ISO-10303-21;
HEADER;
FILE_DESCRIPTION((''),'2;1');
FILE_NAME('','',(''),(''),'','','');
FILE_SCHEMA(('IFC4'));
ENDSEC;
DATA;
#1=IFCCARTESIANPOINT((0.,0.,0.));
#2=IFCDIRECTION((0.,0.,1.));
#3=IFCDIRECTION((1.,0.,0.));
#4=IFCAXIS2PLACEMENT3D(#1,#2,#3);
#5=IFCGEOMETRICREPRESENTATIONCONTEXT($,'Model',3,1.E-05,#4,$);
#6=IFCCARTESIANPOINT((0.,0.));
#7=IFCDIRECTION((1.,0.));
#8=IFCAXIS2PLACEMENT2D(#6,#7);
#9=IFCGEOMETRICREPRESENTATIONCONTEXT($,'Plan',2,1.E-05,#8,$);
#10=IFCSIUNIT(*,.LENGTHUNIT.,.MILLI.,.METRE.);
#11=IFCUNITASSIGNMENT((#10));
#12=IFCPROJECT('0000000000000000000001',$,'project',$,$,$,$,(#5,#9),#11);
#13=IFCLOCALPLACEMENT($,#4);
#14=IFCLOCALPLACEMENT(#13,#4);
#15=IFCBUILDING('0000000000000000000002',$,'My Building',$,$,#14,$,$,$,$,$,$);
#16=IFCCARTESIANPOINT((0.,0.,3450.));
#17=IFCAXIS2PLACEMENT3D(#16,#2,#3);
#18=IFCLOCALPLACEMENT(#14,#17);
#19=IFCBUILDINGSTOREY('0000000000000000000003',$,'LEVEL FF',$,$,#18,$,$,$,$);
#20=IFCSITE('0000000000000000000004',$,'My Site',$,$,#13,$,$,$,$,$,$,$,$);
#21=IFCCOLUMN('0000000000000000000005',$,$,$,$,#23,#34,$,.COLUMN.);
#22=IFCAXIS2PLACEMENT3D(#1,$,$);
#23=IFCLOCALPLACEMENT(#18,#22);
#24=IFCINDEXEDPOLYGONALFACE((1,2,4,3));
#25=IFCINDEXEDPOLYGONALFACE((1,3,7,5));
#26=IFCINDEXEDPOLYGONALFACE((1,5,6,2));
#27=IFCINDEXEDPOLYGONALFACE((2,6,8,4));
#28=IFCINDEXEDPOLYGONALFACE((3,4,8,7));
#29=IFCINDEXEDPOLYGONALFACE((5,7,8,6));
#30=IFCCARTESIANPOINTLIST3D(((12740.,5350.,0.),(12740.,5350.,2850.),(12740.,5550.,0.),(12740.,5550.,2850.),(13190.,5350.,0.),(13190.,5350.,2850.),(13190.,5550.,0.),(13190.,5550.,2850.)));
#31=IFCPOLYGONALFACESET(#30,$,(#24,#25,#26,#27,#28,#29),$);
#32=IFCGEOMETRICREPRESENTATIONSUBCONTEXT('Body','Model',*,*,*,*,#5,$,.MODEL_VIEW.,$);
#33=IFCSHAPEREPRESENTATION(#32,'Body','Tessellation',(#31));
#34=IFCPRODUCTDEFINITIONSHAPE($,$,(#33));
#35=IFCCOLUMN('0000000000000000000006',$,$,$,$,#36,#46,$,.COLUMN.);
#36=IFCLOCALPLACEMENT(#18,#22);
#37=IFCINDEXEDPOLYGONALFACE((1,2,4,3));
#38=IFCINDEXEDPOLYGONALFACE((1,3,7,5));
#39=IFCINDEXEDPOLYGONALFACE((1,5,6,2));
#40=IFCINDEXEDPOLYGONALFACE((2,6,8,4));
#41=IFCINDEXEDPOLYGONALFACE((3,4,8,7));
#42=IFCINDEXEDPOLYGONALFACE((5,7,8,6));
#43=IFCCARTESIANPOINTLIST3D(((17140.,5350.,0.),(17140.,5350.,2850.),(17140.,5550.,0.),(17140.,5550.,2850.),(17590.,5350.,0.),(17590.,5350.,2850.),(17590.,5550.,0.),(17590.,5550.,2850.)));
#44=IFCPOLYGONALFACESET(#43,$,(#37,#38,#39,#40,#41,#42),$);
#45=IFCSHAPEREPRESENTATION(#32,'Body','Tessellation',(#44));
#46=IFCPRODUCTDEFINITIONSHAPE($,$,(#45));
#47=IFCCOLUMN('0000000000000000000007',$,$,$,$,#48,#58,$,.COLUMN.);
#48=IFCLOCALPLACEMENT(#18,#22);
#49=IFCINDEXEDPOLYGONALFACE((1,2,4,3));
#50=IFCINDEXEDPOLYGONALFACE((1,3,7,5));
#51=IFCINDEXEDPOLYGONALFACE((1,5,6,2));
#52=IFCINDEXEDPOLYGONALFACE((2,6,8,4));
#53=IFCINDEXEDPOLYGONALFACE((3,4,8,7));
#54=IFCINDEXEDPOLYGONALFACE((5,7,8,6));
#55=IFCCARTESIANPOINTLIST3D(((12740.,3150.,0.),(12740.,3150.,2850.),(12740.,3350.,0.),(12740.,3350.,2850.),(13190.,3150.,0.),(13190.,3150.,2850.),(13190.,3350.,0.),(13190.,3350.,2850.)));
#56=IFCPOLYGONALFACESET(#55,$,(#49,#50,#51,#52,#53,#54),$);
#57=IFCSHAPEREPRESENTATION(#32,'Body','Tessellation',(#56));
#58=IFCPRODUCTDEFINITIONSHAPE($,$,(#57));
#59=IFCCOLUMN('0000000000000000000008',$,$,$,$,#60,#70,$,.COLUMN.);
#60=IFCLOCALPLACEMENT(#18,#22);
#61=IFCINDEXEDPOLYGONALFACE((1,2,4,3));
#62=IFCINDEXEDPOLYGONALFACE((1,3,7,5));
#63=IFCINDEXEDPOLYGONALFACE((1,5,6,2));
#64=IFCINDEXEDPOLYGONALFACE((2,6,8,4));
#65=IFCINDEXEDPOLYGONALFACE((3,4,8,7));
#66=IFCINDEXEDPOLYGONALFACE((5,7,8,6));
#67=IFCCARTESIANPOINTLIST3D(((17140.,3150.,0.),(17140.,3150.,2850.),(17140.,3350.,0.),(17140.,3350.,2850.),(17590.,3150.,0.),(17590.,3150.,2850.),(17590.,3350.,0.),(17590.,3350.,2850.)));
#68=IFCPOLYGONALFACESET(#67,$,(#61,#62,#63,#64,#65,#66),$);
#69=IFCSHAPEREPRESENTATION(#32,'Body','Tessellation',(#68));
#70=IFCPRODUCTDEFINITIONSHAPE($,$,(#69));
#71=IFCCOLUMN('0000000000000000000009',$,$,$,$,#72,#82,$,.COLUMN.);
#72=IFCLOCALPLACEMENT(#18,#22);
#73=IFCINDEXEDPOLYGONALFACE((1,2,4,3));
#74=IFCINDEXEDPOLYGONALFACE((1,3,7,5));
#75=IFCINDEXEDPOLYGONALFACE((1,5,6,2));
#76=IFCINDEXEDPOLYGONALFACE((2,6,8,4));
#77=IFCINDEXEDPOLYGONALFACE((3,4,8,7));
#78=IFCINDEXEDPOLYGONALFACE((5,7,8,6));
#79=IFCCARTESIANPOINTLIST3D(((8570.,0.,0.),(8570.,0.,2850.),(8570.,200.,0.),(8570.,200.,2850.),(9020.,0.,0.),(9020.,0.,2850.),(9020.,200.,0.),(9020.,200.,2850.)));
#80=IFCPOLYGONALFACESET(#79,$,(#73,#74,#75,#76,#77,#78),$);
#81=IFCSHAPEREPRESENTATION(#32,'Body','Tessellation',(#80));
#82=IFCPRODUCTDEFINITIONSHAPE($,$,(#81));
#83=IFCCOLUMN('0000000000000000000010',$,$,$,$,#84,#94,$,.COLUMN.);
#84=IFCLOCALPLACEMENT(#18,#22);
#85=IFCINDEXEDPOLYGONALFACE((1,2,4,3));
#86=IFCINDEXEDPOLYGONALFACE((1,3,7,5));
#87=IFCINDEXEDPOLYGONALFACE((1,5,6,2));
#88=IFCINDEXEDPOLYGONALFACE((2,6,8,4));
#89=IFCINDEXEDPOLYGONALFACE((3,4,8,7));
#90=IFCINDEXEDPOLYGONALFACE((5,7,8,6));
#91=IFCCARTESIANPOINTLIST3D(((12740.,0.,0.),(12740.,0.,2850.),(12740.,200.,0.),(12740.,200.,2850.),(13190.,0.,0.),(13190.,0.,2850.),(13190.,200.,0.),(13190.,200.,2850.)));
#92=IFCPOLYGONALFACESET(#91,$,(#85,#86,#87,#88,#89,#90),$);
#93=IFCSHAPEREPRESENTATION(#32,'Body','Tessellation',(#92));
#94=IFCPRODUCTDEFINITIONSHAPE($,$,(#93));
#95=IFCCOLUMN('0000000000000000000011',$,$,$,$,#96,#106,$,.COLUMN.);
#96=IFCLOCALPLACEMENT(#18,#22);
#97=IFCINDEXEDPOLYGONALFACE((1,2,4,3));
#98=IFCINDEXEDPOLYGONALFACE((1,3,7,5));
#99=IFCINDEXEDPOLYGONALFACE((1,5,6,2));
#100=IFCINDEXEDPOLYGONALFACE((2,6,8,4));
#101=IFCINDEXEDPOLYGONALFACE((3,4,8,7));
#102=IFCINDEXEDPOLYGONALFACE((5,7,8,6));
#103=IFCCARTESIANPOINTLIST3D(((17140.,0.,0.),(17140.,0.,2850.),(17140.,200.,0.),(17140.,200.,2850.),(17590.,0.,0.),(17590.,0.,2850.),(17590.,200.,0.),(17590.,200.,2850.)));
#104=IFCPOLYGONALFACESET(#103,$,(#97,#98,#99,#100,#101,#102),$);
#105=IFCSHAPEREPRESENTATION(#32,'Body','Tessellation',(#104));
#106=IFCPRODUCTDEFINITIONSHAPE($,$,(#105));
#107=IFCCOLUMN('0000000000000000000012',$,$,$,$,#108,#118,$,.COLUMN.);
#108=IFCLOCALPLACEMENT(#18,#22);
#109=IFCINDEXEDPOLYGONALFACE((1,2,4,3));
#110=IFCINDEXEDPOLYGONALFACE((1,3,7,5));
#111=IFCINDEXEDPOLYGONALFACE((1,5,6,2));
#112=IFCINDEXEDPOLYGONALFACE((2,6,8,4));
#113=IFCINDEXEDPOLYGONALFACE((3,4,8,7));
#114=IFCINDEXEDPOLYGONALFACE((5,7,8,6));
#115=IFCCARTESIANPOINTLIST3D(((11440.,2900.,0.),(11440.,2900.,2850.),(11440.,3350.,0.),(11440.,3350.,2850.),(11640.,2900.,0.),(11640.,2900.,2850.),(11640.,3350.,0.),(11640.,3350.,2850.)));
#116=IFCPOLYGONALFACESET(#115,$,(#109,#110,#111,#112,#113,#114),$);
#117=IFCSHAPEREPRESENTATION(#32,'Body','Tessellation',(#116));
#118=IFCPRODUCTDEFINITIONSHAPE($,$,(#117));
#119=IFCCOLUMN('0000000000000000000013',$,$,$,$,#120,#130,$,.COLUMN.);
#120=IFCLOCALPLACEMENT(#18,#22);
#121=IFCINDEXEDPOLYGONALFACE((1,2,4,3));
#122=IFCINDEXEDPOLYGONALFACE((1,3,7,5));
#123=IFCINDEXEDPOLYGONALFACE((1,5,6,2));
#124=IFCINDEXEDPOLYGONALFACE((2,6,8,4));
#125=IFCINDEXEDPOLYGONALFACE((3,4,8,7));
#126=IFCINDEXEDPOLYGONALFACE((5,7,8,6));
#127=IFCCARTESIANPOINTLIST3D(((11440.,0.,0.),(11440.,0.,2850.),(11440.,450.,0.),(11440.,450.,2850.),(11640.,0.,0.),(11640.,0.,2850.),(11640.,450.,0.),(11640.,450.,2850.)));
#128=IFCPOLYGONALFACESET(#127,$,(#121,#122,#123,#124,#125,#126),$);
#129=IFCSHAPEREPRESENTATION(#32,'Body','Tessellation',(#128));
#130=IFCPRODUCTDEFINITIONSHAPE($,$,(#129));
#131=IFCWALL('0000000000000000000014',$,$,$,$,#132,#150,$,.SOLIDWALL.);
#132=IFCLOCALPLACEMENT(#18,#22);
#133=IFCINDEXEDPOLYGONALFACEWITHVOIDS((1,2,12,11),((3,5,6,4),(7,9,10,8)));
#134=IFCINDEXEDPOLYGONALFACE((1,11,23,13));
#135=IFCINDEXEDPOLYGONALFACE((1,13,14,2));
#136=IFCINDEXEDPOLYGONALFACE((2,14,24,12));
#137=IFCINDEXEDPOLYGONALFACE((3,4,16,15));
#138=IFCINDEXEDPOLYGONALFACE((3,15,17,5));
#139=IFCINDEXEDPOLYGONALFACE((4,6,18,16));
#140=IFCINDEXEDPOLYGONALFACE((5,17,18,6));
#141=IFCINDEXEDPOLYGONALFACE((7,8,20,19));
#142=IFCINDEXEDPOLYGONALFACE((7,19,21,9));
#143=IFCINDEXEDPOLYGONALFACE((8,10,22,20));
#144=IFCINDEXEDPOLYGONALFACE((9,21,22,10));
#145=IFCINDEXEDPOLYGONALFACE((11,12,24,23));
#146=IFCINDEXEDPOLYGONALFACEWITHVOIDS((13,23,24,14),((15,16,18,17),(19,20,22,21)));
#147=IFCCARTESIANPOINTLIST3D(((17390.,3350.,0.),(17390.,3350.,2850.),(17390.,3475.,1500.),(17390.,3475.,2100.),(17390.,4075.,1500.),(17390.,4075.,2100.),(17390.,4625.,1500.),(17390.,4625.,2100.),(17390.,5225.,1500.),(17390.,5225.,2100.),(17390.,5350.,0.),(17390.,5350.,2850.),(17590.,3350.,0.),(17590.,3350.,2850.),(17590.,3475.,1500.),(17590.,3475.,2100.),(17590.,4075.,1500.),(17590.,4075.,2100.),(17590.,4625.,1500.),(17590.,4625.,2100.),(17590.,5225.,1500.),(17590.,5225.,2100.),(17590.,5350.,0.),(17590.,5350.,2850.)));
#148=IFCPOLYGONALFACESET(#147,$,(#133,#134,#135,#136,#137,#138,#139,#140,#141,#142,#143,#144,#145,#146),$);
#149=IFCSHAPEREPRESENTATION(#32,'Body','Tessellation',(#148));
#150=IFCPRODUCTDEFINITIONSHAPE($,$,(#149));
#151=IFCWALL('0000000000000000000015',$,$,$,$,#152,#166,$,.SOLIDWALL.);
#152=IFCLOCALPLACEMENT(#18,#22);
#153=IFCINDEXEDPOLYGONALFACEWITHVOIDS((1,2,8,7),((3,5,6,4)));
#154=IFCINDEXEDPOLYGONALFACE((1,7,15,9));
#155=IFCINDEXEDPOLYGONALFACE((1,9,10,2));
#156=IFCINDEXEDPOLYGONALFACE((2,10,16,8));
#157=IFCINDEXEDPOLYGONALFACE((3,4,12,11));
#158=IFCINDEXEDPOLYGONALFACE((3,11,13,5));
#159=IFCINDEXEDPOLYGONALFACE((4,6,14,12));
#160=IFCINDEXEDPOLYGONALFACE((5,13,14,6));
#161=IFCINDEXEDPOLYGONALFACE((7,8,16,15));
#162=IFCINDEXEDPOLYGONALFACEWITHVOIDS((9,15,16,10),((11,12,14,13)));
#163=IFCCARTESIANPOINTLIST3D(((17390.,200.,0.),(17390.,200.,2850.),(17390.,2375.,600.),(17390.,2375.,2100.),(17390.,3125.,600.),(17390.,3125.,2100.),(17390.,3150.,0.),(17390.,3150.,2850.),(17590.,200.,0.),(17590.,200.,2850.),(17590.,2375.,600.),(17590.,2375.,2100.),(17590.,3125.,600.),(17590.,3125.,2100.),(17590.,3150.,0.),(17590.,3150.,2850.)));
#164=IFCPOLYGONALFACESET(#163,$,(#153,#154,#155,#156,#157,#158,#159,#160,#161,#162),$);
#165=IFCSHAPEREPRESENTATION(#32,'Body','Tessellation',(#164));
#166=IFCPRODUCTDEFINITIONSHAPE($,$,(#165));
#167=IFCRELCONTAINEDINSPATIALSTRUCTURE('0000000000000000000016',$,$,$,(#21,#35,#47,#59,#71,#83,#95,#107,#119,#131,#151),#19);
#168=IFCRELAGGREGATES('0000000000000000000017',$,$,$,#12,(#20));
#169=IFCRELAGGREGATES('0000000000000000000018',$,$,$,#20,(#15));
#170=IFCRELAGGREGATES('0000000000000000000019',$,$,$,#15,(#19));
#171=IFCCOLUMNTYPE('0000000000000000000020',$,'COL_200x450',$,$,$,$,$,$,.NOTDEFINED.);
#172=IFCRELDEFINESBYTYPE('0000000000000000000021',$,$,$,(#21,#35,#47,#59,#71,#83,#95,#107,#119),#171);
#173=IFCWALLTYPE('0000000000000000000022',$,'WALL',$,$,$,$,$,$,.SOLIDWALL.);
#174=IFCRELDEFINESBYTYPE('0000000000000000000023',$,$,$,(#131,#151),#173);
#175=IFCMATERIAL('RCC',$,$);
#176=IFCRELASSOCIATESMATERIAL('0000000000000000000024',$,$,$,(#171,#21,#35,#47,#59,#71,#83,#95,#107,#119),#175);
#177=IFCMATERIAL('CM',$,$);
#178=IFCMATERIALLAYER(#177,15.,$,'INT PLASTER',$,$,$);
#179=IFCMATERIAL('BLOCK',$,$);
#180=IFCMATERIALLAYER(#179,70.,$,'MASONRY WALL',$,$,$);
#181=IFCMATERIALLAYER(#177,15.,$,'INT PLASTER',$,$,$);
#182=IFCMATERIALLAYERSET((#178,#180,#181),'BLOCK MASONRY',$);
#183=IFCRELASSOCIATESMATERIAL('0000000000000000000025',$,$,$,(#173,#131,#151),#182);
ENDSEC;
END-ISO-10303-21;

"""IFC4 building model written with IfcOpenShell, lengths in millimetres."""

from ifc_helpers import new_model, si_unit, frame, origin_with_axes, origin_2d_with_axis, place, context, subcontext, project, spatial, indexed_curve, rectangle, outline, extrude, material, layer, layer_set, layer_usage, material_profile, profile_set, profile_usage, type_object, element, save


model = new_model("IFC4")

# Units and contexts
model_context = context("Model", 3, precision=1e-05, world=origin_with_axes())
plan_context = context("Plan", 2, precision=1e-05, world=origin_2d_with_axis())
body_context = subcontext(model_context, "Body", "Model", "MODEL_VIEW")
ifc_project = project(units=[si_unit("LENGTHUNIT", "METRE", prefix="MILLI")], contexts=[model_context, plan_context])

# Site, building, storey
site_placement = place(None, origin_with_axes())
site = spatial("IfcSite", under=ifc_project, at=site_placement, Name="My Site")
building_placement = place(site_placement, origin_with_axes())
building = spatial("IfcBuilding", under=site, at=building_placement, Name="My Building")
storey_placement = place(building_placement, frame((0.0, 0.0, 3450.0), z_axis=(0.0, 0.0, 1.0), x_axis=(1.0, 0.0, 0.0)))
storey = spatial("IfcBuildingStorey", under=building, at=storey_placement, Name="LEVEL FF")

# Columns
ifc_material_1 = material(Name="RCC")
ifc_material_profile = material_profile(ifc_material_1, rectangle(XDim=200.0, YDim=450.0))
ifc_profile_set = profile_set([ifc_material_profile], Name="COL_200x450")
ifc_profile_usage_1 = profile_usage(ifc_profile_set)
column_type = type_object("IfcColumnType", Name="COL_200x450", PredefinedType="NOTDEFINED", material=ifc_profile_set)
column_1_placement = place(storey_placement, frame((12965.0, 5450.0, 0.0), z_axis=(0.0, 0.0, 1.0), x_axis=(0.0, -1.0, 0.0)))
element("IfcColumn", 1, at=column_1_placement, inside=storey, type_object=column_type, material=ifc_profile_usage_1, PredefinedType="COLUMN", context=body_context, shape_type="SweptSolid", body=[
    extrude(rectangle(XDim=200.0, YDim=450.0), origin_with_axes(), (0.0, 0.0, 1.0), 2850.0),
])
ifc_profile_usage_2 = profile_usage(ifc_profile_set)
column_2_placement = place(storey_placement, frame((17365.0, 5450.0, 0.0), z_axis=(0.0, 0.0, 1.0), x_axis=(0.0, -1.0, 0.0)))
element("IfcColumn", 2, at=column_2_placement, inside=storey, type_object=column_type, material=ifc_profile_usage_2, PredefinedType="COLUMN", context=body_context, shape_type="SweptSolid", body=[
    extrude(rectangle(XDim=200.0, YDim=450.0), origin_with_axes(), (0.0, 0.0, 1.0), 2850.0),
])
ifc_profile_usage_3 = profile_usage(ifc_profile_set)
column_3_placement = place(storey_placement, frame((12965.0, 3250.0, 0.0), z_axis=(0.0, 0.0, 1.0), x_axis=(0.0, -1.0, 0.0)))
element("IfcColumn", 3, at=column_3_placement, inside=storey, type_object=column_type, material=ifc_profile_usage_3, PredefinedType="COLUMN", context=body_context, shape_type="SweptSolid", body=[
    extrude(rectangle(XDim=200.0, YDim=450.0), origin_with_axes(), (0.0, 0.0, 1.0), 2850.0),
])
ifc_profile_usage_4 = profile_usage(ifc_profile_set)
column_4_placement = place(storey_placement, frame((17365.0, 3250.0, 0.0), z_axis=(0.0, 0.0, 1.0), x_axis=(0.0, -1.0, 0.0)))
element("IfcColumn", 4, at=column_4_placement, inside=storey, type_object=column_type, material=ifc_profile_usage_4, PredefinedType="COLUMN", context=body_context, shape_type="SweptSolid", body=[
    extrude(rectangle(XDim=200.0, YDim=450.0), origin_with_axes(), (0.0, 0.0, 1.0), 2850.0),
])
ifc_profile_usage_5 = profile_usage(ifc_profile_set)
column_5_placement = place(storey_placement, frame((8795.0, 100.0, 0.0), z_axis=(0.0, 0.0, 1.0), x_axis=(0.0, -1.0, 0.0)))
element("IfcColumn", 5, at=column_5_placement, inside=storey, type_object=column_type, material=ifc_profile_usage_5, PredefinedType="COLUMN", context=body_context, shape_type="SweptSolid", body=[
    extrude(rectangle(XDim=200.0, YDim=450.0), origin_with_axes(), (0.0, 0.0, 1.0), 2850.0),
])
ifc_profile_usage_6 = profile_usage(ifc_profile_set)
column_6_placement = place(storey_placement, frame((12965.0, 100.0, 0.0), z_axis=(0.0, 0.0, 1.0), x_axis=(0.0, -1.0, 0.0)))
element("IfcColumn", 6, at=column_6_placement, inside=storey, type_object=column_type, material=ifc_profile_usage_6, PredefinedType="COLUMN", context=body_context, shape_type="SweptSolid", body=[
    extrude(rectangle(XDim=200.0, YDim=450.0), origin_with_axes(), (0.0, 0.0, 1.0), 2850.0),
])
ifc_profile_usage_7 = profile_usage(ifc_profile_set)
column_7_placement = place(storey_placement, frame((17365.0, 100.0, 0.0), z_axis=(0.0, 0.0, 1.0), x_axis=(0.0, -1.0, 0.0)))
element("IfcColumn", 7, at=column_7_placement, inside=storey, type_object=column_type, material=ifc_profile_usage_7, PredefinedType="COLUMN", context=body_context, shape_type="SweptSolid", body=[
    extrude(rectangle(XDim=200.0, YDim=450.0), origin_with_axes(), (0.0, 0.0, 1.0), 2850.0),
])
ifc_profile_usage_8 = profile_usage(ifc_profile_set)
column_8_placement = place(storey_placement, frame((11540.0, 3125.0, 0.0), z_axis=(0.0, 0.0, 1.0), x_axis=(1.0, 0.0, 0.0)))
element("IfcColumn", 8, at=column_8_placement, inside=storey, type_object=column_type, material=ifc_profile_usage_8, PredefinedType="COLUMN", context=body_context, shape_type="SweptSolid", body=[
    extrude(rectangle(XDim=200.0, YDim=450.0), origin_with_axes(), (0.0, 0.0, 1.0), 2850.0),
])
ifc_profile_usage_9 = profile_usage(ifc_profile_set)
column_9_placement = place(storey_placement, frame((11540.0, 225.0, 0.0), z_axis=(0.0, 0.0, 1.0), x_axis=(1.0, 0.0, 0.0)))
element("IfcColumn", 9, at=column_9_placement, inside=storey, type_object=column_type, material=ifc_profile_usage_9, PredefinedType="COLUMN", context=body_context, shape_type="SweptSolid", body=[
    extrude(rectangle(XDim=200.0, YDim=450.0), origin_with_axes(), (0.0, 0.0, 1.0), 2850.0),
])

# Wall, openings
ifc_material_2 = material(Name="CM")
ifc_layer_1 = layer(ifc_material_2, 15.0, Name="INT PLASTER")
ifc_material_3 = material(Name="BLOCK")
ifc_layer_2 = layer(ifc_material_3, 70.0, Name="MASONRY WALL")
ifc_layer_3 = layer(ifc_material_2, 15.0, Name="INT PLASTER")
ifc_layer_set = layer_set([ifc_layer_1, ifc_layer_2, ifc_layer_3], Name="BLOCK MASONRY")
ifc_layer_usage_1 = layer_usage(ifc_layer_set, "AXIS2", "POSITIVE", 0.0)
wall_type = type_object("IfcWallType", Name="WALL", PredefinedType="SOLIDWALL", material=ifc_layer_set)
wall_1_placement = place(storey_placement, frame((17590.0, 3350.0, 0.0), z_axis=(0.0, 0.0, 1.0), x_axis=(0.0, 1.0, 0.0)))
wall_1 = element("IfcWall", 10, at=wall_1_placement, inside=storey, type_object=wall_type, material=ifc_layer_usage_1, PredefinedType="SOLIDWALL", context=body_context, shape_type="SweptSolid", body=[
    extrude(outline(indexed_curve([(0.0, 0.0), (0.0, 200.0), (2000.0, 200.0), (2000.0, 0.0), (0.0, 0.0)], self_intersect=False)), origin_with_axes(), (0.0, 0.0, 1.0), 2850.0),
])
opening_1_placement = place(wall_1_placement, frame((1875.0, 200.0, 1500.0), z_axis=(0.0, 0.0, 1.0), x_axis=(-1.0, 0.0, 0.0)))
element("IfcOpeningElement", 11, at=opening_1_placement, cuts=wall_1, PredefinedType="OPENING", context=body_context, shape_type="SweptSolid", body=[
    extrude(outline(indexed_curve([(0.0, 0.0), (0.0, 400.0), (600.0, 400.0), (600.0, 0.0), (0.0, 0.0)], self_intersect=False)), frame((0.0, -100.0, 0.0), z_axis=(0.0, 0.0, 1.0), x_axis=(1.0, 0.0, 0.0)), (0.0, 0.0, 1.0), 600.0),
])
opening_2_placement = place(wall_1_placement, frame((725.0, 200.0, 1500.0), z_axis=(0.0, 0.0, 1.0), x_axis=(-1.0, 0.0, 0.0)))
element("IfcOpeningElement", 12, at=opening_2_placement, cuts=wall_1, PredefinedType="OPENING", context=body_context, shape_type="SweptSolid", body=[
    extrude(outline(indexed_curve([(0.0, 0.0), (0.0, 400.0), (600.0, 400.0), (600.0, 0.0), (0.0, 0.0)], self_intersect=False)), frame((0.0, -100.0, 0.0), z_axis=(0.0, 0.0, 1.0), x_axis=(1.0, 0.0, 0.0)), (0.0, 0.0, 1.0), 600.0),
])

# Wall, opening
ifc_layer_usage_2 = layer_usage(ifc_layer_set, "AXIS2", "POSITIVE", 0.0)
wall_2_placement = place(storey_placement, frame((17590.0, 200.0, 0.0), z_axis=(0.0, 0.0, 1.0), x_axis=(0.0, 1.0, 0.0)))
wall_2 = element("IfcWall", 13, at=wall_2_placement, inside=storey, type_object=wall_type, material=ifc_layer_usage_2, PredefinedType="SOLIDWALL", context=body_context, shape_type="SweptSolid", body=[
    extrude(outline(indexed_curve([(0.0, 0.0), (0.0, 200.0), (2950.0, 200.0), (2950.0, 0.0), (0.0, 0.0)], self_intersect=False)), origin_with_axes(), (0.0, 0.0, 1.0), 2850.0),
])
opening_3_placement = place(wall_2_placement, frame((2925.0, 200.0, 600.0), z_axis=(0.0, 0.0, 1.0), x_axis=(-1.0, 0.0, 0.0)))
element("IfcOpeningElement", 14, at=opening_3_placement, cuts=wall_2, PredefinedType="OPENING", context=body_context, shape_type="SweptSolid", body=[
    extrude(outline(indexed_curve([(0.0, 0.0), (0.0, 400.0), (750.0, 400.0), (750.0, 0.0), (0.0, 0.0)], self_intersect=False)), frame((0.0, -100.0, 0.0), z_axis=(0.0, 0.0, 1.0), x_axis=(1.0, 0.0, 0.0)), (0.0, 0.0, 1.0), 1500.0),
])

save(model, "model.ifc")
